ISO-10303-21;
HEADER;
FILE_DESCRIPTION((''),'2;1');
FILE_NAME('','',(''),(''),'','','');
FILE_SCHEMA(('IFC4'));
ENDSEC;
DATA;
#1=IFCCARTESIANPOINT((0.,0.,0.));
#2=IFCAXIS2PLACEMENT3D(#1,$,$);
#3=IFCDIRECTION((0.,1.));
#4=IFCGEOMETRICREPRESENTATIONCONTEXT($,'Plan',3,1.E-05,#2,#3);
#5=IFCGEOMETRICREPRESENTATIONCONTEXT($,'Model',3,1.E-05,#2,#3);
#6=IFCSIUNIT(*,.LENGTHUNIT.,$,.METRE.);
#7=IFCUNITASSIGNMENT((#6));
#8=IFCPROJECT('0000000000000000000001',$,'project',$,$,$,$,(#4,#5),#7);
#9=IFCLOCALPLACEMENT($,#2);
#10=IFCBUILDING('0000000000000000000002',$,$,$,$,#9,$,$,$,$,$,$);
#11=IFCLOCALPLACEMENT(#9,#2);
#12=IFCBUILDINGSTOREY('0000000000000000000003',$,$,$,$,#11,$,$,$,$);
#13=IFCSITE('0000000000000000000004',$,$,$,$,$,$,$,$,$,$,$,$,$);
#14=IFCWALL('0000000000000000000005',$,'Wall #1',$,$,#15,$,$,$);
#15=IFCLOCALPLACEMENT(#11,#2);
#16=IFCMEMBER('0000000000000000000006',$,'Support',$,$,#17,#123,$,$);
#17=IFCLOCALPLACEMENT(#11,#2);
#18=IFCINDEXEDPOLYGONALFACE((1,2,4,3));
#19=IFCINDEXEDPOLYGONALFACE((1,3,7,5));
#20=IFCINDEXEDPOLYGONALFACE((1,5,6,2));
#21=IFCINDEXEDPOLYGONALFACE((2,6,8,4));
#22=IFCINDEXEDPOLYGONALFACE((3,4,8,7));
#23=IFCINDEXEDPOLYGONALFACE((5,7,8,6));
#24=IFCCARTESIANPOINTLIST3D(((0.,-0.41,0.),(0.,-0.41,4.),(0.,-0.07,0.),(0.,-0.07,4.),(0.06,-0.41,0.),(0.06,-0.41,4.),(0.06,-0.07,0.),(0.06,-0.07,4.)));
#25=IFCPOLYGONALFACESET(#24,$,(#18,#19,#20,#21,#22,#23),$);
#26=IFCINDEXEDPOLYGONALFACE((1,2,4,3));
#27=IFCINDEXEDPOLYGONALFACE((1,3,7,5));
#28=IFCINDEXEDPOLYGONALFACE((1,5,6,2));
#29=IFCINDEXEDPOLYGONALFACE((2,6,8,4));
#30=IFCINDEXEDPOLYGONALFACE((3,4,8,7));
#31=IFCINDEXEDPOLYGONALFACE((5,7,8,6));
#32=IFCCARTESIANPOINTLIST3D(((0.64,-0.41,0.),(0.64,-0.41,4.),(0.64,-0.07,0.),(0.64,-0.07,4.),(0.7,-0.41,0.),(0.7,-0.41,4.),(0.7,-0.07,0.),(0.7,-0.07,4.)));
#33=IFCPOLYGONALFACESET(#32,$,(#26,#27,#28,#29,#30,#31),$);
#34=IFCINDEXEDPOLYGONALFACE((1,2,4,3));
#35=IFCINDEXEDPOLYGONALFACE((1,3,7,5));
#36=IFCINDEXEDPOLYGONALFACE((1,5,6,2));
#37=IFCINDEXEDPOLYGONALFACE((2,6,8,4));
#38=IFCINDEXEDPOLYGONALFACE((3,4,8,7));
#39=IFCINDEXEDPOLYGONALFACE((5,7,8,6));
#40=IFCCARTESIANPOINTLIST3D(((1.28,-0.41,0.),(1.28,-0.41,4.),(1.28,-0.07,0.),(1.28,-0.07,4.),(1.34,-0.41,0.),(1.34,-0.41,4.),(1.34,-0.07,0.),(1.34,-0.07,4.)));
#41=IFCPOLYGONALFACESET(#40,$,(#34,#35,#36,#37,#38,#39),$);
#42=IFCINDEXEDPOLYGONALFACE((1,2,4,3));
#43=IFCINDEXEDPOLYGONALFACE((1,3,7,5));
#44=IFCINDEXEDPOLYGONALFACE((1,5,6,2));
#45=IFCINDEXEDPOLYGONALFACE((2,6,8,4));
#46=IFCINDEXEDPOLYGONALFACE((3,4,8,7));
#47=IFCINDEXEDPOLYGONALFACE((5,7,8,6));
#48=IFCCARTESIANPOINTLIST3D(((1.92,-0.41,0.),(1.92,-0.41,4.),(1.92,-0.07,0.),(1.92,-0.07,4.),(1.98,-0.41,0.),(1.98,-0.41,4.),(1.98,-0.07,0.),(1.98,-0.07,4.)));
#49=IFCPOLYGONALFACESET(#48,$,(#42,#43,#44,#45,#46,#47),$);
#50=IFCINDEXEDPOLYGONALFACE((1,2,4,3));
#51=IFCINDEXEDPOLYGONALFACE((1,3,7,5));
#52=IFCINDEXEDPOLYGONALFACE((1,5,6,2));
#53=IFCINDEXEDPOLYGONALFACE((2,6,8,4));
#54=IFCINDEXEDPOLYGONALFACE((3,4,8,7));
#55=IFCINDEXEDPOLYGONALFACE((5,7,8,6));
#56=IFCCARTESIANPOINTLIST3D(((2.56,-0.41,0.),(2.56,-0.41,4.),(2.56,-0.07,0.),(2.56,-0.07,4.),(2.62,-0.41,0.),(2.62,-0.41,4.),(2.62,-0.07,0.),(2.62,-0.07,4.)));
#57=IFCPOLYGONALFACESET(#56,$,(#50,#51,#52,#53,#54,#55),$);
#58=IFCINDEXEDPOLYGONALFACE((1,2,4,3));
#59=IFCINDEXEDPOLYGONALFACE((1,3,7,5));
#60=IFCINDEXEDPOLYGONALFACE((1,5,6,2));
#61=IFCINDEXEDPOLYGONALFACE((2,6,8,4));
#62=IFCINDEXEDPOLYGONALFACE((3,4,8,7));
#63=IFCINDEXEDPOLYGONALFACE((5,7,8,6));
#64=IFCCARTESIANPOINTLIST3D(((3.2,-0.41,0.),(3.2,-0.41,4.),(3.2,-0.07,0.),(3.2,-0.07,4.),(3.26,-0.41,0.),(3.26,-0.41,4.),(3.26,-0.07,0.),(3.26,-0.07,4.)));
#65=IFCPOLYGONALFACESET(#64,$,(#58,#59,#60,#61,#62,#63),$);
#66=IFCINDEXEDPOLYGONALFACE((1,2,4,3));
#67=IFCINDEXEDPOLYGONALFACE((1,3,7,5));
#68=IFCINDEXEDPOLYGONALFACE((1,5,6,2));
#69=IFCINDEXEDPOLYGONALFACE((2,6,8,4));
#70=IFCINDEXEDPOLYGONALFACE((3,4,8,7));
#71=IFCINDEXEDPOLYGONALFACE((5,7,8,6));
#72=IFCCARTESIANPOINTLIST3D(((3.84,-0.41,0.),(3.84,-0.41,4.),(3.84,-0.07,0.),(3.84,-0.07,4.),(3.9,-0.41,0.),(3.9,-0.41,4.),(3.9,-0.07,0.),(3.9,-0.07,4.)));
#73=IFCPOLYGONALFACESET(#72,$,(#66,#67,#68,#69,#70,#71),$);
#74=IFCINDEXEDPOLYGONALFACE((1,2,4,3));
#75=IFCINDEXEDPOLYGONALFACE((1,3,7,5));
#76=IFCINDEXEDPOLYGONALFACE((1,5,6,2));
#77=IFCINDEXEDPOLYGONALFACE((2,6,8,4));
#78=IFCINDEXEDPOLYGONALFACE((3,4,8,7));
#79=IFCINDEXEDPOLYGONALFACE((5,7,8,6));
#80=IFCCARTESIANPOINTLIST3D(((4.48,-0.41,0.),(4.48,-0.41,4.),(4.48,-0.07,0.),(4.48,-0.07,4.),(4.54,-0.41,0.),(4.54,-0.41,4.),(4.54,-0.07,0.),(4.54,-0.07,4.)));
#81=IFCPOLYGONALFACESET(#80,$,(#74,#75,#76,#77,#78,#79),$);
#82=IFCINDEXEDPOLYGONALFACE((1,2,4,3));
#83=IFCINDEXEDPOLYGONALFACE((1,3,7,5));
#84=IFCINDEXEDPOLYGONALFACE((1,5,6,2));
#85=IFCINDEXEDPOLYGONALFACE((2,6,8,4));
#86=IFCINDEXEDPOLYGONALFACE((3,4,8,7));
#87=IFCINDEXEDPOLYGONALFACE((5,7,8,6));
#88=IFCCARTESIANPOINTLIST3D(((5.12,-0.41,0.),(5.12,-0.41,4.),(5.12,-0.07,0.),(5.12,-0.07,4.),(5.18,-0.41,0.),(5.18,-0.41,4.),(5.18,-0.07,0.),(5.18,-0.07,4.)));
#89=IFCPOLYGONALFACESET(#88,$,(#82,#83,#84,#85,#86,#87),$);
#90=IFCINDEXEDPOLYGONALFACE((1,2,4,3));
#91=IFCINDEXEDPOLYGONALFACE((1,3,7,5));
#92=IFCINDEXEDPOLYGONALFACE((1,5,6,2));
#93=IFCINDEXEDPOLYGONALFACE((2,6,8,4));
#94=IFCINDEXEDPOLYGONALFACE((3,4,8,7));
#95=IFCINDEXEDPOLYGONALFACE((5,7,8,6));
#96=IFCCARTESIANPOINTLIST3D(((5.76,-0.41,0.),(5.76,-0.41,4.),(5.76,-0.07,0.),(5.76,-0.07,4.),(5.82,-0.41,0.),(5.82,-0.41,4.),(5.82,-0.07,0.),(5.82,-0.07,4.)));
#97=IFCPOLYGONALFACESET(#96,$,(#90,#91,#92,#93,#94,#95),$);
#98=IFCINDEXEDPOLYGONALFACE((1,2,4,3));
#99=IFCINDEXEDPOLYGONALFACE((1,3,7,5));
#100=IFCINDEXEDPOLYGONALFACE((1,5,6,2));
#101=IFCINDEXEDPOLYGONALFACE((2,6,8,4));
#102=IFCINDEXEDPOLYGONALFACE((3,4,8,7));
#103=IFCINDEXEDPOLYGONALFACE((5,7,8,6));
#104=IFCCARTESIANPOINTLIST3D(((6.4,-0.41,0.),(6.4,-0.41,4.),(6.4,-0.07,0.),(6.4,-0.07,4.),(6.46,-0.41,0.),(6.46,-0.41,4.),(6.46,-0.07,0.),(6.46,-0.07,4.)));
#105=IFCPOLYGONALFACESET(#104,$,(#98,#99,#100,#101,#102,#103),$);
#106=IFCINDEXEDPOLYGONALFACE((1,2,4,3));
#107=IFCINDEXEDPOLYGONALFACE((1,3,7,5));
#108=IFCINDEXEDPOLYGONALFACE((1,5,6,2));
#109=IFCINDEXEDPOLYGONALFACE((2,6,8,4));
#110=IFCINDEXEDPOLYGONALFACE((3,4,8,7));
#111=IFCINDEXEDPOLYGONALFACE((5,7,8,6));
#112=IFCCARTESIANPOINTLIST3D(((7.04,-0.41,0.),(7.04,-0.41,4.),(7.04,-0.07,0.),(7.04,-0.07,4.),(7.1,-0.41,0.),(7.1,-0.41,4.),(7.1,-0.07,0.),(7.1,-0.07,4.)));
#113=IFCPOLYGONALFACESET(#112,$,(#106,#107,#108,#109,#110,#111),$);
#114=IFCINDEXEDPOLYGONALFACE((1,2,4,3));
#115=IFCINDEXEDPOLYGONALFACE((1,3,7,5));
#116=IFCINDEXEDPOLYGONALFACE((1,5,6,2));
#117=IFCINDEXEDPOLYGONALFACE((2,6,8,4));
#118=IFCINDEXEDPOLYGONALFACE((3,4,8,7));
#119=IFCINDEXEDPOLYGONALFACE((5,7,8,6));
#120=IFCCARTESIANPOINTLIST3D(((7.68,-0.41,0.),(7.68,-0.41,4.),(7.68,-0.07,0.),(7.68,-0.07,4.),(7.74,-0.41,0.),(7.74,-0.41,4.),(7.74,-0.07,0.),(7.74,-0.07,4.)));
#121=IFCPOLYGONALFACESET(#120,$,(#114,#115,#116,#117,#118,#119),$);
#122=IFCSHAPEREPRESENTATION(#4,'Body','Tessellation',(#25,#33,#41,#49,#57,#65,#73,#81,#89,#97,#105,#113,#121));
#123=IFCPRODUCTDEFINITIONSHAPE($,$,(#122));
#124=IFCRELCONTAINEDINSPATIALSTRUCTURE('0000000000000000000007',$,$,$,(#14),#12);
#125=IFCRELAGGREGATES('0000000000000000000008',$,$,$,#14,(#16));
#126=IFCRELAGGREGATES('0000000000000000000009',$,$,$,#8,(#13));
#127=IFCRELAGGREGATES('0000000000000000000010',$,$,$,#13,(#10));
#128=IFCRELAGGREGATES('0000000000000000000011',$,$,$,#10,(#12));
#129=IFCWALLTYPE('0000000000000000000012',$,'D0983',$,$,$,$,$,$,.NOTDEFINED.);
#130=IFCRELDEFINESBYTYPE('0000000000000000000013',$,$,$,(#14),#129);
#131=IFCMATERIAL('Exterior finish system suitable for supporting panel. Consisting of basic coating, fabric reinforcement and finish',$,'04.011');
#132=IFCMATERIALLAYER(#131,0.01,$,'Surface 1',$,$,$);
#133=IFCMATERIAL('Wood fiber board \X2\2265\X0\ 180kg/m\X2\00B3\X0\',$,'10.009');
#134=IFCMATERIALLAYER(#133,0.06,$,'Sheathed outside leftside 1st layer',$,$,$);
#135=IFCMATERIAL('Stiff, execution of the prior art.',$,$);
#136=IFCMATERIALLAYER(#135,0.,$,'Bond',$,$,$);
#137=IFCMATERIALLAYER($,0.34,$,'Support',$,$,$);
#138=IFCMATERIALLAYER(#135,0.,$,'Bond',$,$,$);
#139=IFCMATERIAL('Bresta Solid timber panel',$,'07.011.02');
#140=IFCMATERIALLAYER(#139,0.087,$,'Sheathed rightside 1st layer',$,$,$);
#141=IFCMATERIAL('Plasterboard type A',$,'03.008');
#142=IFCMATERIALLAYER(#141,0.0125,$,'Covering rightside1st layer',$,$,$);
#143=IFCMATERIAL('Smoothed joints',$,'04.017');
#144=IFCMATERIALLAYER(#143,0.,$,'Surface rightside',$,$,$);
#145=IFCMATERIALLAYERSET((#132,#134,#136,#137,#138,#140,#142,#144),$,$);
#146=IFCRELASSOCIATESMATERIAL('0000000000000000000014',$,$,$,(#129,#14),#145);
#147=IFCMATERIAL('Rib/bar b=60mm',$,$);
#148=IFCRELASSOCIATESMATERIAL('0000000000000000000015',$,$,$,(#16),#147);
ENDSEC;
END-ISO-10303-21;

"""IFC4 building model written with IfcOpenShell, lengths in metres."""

from ifc_helpers import new_model, si_unit, direction, frame, frame_2d, origin, place, context, project, spatial, rectangle, extrude, material, layer, layer_set, type_object, element, aggregate, save


model = new_model("IFC4")

# Units and contexts
plan_context = context("Plan", 3, precision=1e-05, world=origin(), true_north=direction((0.0, 1.0)))
model_context = context("Model", 3, precision=1e-05, world=origin(), true_north=direction((0.0, 1.0)))
ifc_project = project(units=[si_unit("LENGTHUNIT", "METRE")], contexts=[plan_context, model_context])

# Site, building, storey
site = spatial("IfcSite", under=ifc_project)
building_placement = place(None, origin())
building = spatial("IfcBuilding", under=site, at=building_placement)
storey_placement = place(building_placement, origin())
storey = spatial("IfcBuildingStorey", under=building, at=storey_placement)

# Wall, member
ifc_material_1 = material(Name="Exterior finish system suitable for supporting panel. Consisting of basic coating, fabric reinforcement and finish", Category="04.011")
ifc_layer_1 = layer(ifc_material_1, 0.01, Name="Surface 1")
ifc_material_2 = material(Name="Wood fiber board ≥ 180kg/m³", Category="10.009")
ifc_layer_2 = layer(ifc_material_2, 0.06, Name="Sheathed outside leftside 1st layer")
ifc_material_3 = material(Name="Stiff, execution of the prior art.")
ifc_layer_3 = layer(ifc_material_3, 0.0, Name="Bond")
ifc_layer_4 = layer(None, 0.34, Name="Support")
ifc_layer_5 = layer(ifc_material_3, 0.0, Name="Bond")
ifc_material_4 = material(Name="Bresta Solid timber panel", Category="07.011.02")
ifc_layer_6 = layer(ifc_material_4, 0.087, Name="Sheathed rightside 1st layer")
ifc_material_5 = material(Name="Plasterboard type A", Category="03.008")
ifc_layer_7 = layer(ifc_material_5, 0.0125, Name="Covering rightside1st layer")
ifc_material_6 = material(Name="Smoothed joints", Category="04.017")
ifc_layer_8 = layer(ifc_material_6, 0.0, Name="Surface rightside")
ifc_layer_set = layer_set([ifc_layer_1, ifc_layer_2, ifc_layer_3, ifc_layer_4, ifc_layer_5, ifc_layer_6, ifc_layer_7, ifc_layer_8])
wall_type = type_object("IfcWallType", Name="D0983", PredefinedType="NOTDEFINED", material=ifc_layer_set)
wall_placement = place(None, frame((0.0, 0.0, 0.0), z_axis=(0.0, -1.0, 0.0), x_axis=(1.0, 0.0, 0.0)))
wall = element("IfcWall", 1, at=wall_placement, inside=storey, type_object=wall_type, material=ifc_layer_set, Name="Wall #1")
ifc_material_7 = material(Name="Rib/bar b=60mm")
member_1_placement = place(wall_placement, origin())
member_1 = element("IfcMember", 2, at=member_1_placement, material=ifc_material_7, Name="Support", context=plan_context, shape_type="SweptSolid", body=[
    extrude(rectangle(XDim=0.06, YDim=0.34, at=frame_2d((0.03, 0.17), x_axis=(1.0, 0.0))), frame((0.0, 4.0, 0.07), z_axis=(0.0, -1.0, 0.0), x_axis=(1.0, 0.0, 0.0)), (0.0, 0.0, 1.0), 4.0),
    extrude(rectangle(XDim=0.06, YDim=0.34, at=frame_2d((0.03, 0.17), x_axis=(1.0, 0.0))), frame((0.64, 4.0, 0.07), z_axis=(0.0, -1.0, 0.0), x_axis=(1.0, 0.0, 0.0)), (0.0, 0.0, 1.0), 4.0),
    extrude(rectangle(XDim=0.06, YDim=0.34, at=frame_2d((0.03, 0.17), x_axis=(1.0, 0.0))), frame((1.28, 4.0, 0.07), z_axis=(0.0, -1.0, 0.0), x_axis=(1.0, 0.0, 0.0)), (0.0, 0.0, 1.0), 4.0),
    extrude(rectangle(XDim=0.06, YDim=0.34, at=frame_2d((0.03, 0.17), x_axis=(1.0, 0.0))), frame((1.92, 4.0, 0.07), z_axis=(0.0, -1.0, 0.0), x_axis=(1.0, 0.0, 0.0)), (0.0, 0.0, 1.0), 4.0),
    extrude(rectangle(XDim=0.06, YDim=0.34, at=frame_2d((0.03, 0.17), x_axis=(1.0, 0.0))), frame((2.56, 4.0, 0.07), z_axis=(0.0, -1.0, 0.0), x_axis=(1.0, 0.0, 0.0)), (0.0, 0.0, 1.0), 4.0),
    extrude(rectangle(XDim=0.06, YDim=0.34, at=frame_2d((0.03, 0.17), x_axis=(1.0, 0.0))), frame((3.2, 4.0, 0.07), z_axis=(0.0, -1.0, 0.0), x_axis=(1.0, 0.0, 0.0)), (0.0, 0.0, 1.0), 4.0),
    extrude(rectangle(XDim=0.06, YDim=0.34, at=frame_2d((0.03, 0.17), x_axis=(1.0, 0.0))), frame((3.84, 4.0, 0.07), z_axis=(0.0, -1.0, 0.0), x_axis=(1.0, 0.0, 0.0)), (0.0, 0.0, 1.0), 4.0),
    extrude(rectangle(XDim=0.06, YDim=0.34, at=frame_2d((0.03, 0.17), x_axis=(1.0, 0.0))), frame((4.48, 4.0, 0.07), z_axis=(0.0, -1.0, 0.0), x_axis=(1.0, 0.0, 0.0)), (0.0, 0.0, 1.0), 4.0),
    extrude(rectangle(XDim=0.06, YDim=0.34, at=frame_2d((0.03, 0.17), x_axis=(1.0, 0.0))), frame((5.12, 4.0, 0.07), z_axis=(0.0, -1.0, 0.0), x_axis=(1.0, 0.0, 0.0)), (0.0, 0.0, 1.0), 4.0),
    extrude(rectangle(XDim=0.06, YDim=0.34, at=frame_2d((0.03, 0.17), x_axis=(1.0, 0.0))), frame((5.76, 4.0, 0.07), z_axis=(0.0, -1.0, 0.0), x_axis=(1.0, 0.0, 0.0)), (0.0, 0.0, 1.0), 4.0),
    extrude(rectangle(XDim=0.06, YDim=0.34, at=frame_2d((0.03, 0.17), x_axis=(1.0, 0.0))), frame((6.4, 4.0, 0.07), z_axis=(0.0, -1.0, 0.0), x_axis=(1.0, 0.0, 0.0)), (0.0, 0.0, 1.0), 4.0),
    extrude(rectangle(XDim=0.06, YDim=0.34, at=frame_2d((0.03, 0.17), x_axis=(1.0, 0.0))), frame((7.04, 4.0, 0.07), z_axis=(0.0, -1.0, 0.0), x_axis=(1.0, 0.0, 0.0)), (0.0, 0.0, 1.0), 4.0),
    extrude(rectangle(XDim=0.06, YDim=0.34, at=frame_2d((0.03, 0.17), x_axis=(1.0, 0.0))), frame((7.68, 4.0, 0.07), z_axis=(0.0, -1.0, 0.0), x_axis=(1.0, 0.0, 0.0)), (0.0, 0.0, 1.0), 4.0),
])
aggregate(wall, [member_1])

save(model, "model.ifc")
